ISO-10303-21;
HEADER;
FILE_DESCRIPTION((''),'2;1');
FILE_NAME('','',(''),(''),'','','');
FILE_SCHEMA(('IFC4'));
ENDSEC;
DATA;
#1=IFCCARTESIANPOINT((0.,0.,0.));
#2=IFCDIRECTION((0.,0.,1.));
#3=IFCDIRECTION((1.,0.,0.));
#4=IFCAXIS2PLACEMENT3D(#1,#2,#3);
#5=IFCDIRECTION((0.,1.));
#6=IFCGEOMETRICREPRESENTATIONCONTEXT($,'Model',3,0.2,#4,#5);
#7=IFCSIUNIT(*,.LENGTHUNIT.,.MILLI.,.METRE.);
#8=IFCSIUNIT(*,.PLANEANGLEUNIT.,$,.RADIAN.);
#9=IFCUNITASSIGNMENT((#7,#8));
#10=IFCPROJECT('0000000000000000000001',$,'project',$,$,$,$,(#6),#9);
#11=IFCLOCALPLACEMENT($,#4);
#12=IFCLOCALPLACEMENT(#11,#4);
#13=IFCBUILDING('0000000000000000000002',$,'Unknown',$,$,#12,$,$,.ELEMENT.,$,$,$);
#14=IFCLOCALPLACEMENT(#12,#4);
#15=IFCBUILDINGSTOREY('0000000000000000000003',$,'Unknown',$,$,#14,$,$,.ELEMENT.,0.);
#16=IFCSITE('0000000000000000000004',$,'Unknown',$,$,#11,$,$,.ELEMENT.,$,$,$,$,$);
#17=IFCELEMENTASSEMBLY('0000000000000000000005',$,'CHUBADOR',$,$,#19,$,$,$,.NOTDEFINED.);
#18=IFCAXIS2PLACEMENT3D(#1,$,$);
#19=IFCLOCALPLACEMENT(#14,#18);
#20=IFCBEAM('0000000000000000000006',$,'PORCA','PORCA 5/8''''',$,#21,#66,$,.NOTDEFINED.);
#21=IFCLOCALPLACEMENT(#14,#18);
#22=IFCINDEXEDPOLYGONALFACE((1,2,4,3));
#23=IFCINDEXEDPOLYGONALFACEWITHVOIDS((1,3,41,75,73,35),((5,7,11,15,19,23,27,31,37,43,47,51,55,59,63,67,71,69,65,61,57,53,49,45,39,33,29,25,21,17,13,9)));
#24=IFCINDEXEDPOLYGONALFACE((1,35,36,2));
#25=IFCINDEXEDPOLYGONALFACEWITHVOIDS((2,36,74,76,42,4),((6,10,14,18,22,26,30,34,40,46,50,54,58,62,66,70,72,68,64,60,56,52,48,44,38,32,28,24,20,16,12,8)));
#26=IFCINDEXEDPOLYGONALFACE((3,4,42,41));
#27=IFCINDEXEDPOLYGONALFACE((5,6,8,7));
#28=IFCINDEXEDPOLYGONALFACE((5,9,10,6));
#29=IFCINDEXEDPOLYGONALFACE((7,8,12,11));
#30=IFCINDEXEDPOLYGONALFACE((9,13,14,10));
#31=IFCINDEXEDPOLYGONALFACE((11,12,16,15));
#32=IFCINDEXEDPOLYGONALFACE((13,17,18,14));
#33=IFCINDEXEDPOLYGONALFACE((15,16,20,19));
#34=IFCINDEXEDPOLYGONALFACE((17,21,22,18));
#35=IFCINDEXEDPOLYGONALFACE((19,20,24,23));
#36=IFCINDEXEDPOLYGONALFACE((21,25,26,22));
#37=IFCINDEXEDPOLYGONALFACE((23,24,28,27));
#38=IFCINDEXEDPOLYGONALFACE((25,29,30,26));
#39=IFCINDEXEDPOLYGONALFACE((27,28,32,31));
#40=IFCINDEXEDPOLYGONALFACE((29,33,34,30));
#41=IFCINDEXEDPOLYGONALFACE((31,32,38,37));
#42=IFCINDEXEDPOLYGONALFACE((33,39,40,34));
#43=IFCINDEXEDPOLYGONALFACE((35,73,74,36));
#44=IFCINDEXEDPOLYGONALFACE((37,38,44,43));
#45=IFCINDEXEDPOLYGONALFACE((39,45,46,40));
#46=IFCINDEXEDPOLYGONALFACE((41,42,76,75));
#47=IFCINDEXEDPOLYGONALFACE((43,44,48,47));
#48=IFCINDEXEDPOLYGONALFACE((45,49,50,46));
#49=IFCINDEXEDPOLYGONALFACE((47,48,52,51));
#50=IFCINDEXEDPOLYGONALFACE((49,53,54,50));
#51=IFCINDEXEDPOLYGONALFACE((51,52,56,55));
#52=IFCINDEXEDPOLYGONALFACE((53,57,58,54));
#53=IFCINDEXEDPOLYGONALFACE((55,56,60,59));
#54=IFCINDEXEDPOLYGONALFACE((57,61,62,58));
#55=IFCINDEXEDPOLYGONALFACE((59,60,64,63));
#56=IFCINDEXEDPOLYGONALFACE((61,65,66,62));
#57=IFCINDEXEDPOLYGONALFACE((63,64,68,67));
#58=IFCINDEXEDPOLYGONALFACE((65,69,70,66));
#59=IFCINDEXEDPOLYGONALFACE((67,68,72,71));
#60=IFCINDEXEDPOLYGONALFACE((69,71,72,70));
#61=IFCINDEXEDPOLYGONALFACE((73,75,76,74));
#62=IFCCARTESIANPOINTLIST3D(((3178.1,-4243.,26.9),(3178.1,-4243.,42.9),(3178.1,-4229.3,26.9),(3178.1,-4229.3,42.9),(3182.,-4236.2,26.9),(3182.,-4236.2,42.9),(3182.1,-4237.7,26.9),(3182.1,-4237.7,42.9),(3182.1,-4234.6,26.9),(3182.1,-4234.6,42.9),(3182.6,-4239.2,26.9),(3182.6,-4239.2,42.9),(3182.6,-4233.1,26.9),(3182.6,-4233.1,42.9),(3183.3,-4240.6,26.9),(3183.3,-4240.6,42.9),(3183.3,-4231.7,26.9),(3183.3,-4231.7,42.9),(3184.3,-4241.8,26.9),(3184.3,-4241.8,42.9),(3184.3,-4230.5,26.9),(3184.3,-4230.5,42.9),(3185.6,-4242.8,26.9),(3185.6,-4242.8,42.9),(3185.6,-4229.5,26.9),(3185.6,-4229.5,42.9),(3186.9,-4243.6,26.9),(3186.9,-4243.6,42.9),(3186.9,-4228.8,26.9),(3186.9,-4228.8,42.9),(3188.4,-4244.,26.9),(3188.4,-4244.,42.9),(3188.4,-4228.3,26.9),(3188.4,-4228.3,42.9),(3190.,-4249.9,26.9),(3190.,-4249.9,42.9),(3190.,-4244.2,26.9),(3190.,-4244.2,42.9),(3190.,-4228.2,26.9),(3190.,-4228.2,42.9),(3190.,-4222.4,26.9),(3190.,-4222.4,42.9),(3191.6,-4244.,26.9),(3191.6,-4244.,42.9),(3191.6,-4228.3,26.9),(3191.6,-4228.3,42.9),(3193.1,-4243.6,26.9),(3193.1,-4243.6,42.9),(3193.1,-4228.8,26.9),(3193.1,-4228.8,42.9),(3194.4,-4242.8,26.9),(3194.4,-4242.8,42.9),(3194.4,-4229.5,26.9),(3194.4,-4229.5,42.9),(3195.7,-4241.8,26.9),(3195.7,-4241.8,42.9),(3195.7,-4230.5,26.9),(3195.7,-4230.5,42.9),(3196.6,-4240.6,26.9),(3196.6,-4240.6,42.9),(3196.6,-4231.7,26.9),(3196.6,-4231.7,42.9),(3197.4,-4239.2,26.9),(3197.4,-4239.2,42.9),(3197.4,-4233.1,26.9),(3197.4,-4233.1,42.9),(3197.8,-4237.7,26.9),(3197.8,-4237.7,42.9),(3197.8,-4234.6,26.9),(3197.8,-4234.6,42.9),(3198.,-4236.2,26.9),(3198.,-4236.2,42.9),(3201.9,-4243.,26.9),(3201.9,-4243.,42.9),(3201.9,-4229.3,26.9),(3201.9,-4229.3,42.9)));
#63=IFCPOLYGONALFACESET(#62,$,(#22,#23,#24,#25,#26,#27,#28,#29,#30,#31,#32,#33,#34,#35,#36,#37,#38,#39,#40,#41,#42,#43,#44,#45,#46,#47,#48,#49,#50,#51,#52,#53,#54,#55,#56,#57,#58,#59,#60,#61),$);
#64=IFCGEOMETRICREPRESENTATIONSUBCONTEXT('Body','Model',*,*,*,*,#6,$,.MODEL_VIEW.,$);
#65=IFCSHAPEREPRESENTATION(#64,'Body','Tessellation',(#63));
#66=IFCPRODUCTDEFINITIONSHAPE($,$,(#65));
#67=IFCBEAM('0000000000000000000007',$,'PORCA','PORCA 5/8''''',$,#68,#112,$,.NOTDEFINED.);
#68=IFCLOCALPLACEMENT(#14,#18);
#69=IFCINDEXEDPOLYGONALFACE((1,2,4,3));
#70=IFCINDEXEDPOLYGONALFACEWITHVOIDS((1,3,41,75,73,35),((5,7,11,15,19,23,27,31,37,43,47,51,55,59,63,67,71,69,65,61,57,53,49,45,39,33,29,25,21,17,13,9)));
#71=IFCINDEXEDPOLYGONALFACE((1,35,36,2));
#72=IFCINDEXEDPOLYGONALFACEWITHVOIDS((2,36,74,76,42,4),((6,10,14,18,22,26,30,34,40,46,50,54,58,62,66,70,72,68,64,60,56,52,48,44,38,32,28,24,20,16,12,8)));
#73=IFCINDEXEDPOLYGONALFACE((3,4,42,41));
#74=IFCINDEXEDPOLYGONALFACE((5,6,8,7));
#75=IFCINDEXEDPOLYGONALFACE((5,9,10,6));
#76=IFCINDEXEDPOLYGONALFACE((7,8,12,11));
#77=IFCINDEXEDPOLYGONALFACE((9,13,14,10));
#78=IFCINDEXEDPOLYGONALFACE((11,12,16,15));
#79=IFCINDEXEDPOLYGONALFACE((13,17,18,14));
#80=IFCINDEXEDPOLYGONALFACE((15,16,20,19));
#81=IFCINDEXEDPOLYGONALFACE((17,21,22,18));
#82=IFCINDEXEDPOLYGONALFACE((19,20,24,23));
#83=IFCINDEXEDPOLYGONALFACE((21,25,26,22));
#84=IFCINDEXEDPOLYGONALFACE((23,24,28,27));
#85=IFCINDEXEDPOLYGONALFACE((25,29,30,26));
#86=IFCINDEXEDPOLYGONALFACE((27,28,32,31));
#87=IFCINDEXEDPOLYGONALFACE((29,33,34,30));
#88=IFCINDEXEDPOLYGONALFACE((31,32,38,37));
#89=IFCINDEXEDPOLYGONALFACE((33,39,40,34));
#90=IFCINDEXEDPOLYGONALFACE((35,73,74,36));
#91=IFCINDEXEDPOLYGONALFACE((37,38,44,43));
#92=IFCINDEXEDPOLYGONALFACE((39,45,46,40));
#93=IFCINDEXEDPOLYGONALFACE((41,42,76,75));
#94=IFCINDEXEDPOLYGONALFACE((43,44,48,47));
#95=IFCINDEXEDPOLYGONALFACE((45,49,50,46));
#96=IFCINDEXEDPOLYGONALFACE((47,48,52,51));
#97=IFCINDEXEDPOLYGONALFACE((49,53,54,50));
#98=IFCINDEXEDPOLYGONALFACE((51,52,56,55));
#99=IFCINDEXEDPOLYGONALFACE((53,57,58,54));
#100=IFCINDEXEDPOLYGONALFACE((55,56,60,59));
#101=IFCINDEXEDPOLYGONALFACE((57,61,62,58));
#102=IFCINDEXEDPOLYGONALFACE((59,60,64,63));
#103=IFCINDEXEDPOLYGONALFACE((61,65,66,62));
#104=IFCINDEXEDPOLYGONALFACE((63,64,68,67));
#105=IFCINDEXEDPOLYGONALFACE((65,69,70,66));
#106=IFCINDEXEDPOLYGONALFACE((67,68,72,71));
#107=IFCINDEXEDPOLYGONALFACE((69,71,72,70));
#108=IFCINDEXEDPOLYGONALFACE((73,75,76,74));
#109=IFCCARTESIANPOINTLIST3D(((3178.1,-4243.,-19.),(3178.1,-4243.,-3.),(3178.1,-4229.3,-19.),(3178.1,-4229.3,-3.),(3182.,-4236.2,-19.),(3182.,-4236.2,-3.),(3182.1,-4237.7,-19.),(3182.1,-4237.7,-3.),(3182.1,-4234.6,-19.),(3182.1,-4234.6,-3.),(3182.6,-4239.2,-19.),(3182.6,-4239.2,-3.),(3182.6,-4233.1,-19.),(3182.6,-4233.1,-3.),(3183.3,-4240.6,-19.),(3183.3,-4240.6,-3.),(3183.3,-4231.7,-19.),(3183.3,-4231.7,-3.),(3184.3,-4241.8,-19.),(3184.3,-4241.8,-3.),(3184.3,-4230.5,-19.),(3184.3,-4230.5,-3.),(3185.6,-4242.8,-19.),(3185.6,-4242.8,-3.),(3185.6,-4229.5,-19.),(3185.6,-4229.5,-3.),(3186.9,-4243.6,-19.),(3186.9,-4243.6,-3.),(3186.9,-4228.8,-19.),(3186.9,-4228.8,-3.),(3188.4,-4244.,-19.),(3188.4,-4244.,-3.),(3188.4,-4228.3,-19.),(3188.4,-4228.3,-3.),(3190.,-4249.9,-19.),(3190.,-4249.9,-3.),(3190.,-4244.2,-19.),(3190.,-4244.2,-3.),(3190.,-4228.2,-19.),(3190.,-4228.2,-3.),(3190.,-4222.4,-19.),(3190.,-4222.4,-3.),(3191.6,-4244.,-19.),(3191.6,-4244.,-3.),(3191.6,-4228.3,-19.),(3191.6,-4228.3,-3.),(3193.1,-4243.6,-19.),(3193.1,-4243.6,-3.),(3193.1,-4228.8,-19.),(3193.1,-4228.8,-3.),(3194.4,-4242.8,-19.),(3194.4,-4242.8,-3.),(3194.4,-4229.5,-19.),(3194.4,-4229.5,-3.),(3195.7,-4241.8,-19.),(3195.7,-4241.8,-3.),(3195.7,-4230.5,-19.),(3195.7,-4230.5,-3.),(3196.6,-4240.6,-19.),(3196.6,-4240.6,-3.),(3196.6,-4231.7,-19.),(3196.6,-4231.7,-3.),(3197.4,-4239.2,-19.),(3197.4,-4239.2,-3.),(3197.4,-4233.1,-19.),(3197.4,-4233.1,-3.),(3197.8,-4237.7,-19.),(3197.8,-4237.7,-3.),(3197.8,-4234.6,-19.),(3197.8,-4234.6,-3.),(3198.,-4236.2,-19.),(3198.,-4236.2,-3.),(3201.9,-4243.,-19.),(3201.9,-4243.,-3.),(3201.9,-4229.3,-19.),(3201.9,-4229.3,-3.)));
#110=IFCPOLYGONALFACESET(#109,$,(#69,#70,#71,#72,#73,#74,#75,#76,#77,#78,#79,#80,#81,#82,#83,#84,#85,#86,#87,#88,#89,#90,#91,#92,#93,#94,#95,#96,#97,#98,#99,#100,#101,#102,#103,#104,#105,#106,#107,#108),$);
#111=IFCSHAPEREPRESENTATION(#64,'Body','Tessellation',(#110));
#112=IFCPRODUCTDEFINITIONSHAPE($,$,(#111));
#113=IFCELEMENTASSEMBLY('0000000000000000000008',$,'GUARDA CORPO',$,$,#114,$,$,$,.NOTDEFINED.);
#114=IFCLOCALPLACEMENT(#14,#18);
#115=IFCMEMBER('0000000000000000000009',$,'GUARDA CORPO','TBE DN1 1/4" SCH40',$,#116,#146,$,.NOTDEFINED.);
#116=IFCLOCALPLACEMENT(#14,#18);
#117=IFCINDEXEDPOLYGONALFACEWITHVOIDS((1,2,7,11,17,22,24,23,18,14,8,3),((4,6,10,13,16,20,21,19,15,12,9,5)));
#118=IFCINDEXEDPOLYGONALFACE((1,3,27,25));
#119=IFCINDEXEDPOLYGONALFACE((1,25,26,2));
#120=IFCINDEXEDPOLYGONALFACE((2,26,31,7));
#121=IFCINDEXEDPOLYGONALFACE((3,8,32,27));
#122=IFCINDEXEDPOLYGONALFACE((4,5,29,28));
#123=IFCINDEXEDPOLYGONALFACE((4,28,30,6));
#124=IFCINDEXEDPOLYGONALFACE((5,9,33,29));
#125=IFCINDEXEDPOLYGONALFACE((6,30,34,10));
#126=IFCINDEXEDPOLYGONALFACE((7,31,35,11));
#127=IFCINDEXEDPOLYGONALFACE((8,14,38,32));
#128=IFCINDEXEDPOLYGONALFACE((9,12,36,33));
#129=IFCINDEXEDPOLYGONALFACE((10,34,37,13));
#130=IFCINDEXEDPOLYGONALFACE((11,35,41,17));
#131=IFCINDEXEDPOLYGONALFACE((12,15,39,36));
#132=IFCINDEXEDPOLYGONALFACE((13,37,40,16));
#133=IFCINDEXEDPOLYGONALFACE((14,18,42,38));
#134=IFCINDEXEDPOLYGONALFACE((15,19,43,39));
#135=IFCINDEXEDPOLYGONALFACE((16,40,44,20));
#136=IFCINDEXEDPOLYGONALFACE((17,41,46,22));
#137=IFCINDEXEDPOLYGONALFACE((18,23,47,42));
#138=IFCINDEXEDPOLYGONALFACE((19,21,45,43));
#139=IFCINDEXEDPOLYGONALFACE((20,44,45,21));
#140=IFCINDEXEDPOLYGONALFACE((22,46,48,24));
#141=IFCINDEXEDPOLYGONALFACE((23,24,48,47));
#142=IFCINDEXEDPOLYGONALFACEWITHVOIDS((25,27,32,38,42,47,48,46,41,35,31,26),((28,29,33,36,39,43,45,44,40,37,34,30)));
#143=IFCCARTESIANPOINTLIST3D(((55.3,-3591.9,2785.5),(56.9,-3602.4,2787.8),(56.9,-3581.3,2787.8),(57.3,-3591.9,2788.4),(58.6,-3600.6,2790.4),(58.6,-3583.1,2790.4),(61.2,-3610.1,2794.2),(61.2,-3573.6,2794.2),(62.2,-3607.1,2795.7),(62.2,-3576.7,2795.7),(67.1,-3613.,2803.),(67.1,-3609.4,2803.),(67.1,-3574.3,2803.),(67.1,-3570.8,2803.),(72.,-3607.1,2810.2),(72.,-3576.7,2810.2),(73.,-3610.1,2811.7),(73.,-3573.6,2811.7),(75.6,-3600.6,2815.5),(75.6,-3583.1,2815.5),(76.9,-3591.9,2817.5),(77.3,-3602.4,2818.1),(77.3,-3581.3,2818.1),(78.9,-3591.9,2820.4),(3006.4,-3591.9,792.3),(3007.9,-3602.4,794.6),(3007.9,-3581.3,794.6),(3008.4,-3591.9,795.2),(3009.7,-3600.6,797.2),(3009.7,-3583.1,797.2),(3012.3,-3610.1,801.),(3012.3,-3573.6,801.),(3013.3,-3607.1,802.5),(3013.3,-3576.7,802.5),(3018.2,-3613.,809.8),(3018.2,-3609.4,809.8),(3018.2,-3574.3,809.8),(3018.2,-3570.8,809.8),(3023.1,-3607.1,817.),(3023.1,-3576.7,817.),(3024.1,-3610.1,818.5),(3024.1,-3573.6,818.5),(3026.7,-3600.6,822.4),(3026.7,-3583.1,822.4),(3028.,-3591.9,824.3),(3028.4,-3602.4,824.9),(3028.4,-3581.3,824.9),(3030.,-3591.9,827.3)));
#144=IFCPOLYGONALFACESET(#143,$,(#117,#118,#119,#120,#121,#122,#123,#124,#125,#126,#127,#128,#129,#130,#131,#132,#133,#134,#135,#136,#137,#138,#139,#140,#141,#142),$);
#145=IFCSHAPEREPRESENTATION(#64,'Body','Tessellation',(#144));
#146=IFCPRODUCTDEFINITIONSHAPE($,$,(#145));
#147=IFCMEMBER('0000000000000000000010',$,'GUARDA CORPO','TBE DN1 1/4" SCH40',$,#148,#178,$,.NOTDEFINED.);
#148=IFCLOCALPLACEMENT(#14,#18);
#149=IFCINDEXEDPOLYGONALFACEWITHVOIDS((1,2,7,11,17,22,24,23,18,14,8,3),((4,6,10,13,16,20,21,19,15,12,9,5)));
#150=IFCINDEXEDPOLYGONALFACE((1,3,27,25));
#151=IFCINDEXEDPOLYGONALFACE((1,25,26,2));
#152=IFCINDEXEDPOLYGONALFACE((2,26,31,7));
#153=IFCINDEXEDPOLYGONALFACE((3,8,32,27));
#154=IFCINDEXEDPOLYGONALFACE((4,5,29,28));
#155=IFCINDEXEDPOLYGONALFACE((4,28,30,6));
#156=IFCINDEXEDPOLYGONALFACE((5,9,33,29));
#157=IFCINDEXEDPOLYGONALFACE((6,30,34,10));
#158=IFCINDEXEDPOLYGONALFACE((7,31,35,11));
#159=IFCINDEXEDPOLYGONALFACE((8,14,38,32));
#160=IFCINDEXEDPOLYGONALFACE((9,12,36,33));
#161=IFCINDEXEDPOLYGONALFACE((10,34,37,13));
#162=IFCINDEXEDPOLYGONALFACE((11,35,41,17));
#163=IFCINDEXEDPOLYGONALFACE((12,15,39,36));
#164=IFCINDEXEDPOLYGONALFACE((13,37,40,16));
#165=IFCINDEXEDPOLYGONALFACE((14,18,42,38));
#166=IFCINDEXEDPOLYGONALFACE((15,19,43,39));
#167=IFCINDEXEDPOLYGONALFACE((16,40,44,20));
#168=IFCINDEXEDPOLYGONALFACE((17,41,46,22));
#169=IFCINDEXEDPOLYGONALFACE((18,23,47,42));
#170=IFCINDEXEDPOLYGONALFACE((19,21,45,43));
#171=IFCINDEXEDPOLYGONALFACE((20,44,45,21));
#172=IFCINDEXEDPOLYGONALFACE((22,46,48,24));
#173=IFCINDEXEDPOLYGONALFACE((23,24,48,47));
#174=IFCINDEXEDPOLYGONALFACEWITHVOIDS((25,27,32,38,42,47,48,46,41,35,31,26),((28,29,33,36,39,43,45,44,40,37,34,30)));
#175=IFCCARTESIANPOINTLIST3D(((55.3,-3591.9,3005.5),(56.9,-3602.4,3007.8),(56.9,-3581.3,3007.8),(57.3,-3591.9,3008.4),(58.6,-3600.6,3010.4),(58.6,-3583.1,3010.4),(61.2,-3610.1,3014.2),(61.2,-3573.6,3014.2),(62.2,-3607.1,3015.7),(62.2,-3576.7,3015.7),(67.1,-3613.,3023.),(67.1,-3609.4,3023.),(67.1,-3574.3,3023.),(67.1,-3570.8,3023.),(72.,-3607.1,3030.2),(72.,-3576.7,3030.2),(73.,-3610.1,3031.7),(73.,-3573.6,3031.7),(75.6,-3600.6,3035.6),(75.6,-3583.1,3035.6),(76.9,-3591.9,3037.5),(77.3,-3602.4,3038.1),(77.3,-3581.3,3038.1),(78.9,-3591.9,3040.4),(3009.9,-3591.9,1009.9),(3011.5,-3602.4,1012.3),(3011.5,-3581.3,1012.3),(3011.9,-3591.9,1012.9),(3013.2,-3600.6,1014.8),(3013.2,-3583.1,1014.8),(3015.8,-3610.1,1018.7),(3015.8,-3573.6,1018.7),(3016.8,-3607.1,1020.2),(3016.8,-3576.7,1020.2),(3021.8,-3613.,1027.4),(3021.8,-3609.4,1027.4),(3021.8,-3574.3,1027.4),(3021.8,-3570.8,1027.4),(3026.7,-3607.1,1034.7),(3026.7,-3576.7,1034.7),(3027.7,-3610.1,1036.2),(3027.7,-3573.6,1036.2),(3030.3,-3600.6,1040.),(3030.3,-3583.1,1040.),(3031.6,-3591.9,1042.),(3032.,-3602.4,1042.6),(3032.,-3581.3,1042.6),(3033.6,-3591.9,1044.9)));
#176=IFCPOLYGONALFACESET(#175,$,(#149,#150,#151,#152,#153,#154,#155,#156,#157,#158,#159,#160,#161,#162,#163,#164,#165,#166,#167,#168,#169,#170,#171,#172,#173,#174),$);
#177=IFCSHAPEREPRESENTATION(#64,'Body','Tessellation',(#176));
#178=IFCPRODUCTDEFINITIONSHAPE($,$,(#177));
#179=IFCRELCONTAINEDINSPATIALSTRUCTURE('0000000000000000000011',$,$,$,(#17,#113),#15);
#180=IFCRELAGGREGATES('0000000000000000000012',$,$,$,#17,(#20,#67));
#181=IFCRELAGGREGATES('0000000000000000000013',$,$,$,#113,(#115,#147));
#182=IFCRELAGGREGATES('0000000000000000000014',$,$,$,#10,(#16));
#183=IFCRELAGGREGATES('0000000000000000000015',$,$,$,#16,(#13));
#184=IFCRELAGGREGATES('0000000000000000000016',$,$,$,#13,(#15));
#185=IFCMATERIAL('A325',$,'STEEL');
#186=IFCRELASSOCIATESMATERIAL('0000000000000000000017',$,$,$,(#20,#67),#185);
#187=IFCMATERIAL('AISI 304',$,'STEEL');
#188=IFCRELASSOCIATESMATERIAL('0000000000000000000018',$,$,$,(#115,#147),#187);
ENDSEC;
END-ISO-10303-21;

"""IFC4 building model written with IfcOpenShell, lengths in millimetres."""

from ifc_helpers import new_model, si_unit, direction, frame, origin_with_axes, place, context, subcontext, project, spatial, line, indexed_curve, outline, extrude, material, element, aggregate, save


model = new_model("IFC4")

# Units and contexts
model_context = context("Model", 3, precision=0.2, world=origin_with_axes(), true_north=direction((0.0, 1.0)))
body_context = subcontext(model_context, "Body", "Model", "MODEL_VIEW")
ifc_project = project(units=[si_unit("LENGTHUNIT", "METRE", prefix="MILLI"), si_unit("PLANEANGLEUNIT", "RADIAN")], contexts=[model_context])

# Site, building, storey
site_placement = place(None, origin_with_axes())
site = spatial("IfcSite", under=ifc_project, at=site_placement, Name="Unknown", CompositionType="ELEMENT")
building_placement = place(site_placement, origin_with_axes())
building = spatial("IfcBuilding", under=site, at=building_placement, Name="Unknown", CompositionType="ELEMENT")
storey_placement = place(building_placement, origin_with_axes())
storey = spatial("IfcBuildingStorey", under=building, at=storey_placement, Name="Unknown", CompositionType="ELEMENT", Elevation=0.0)

# Element assembly, beams
ifc_material_1 = material(Name="A325", Category="STEEL")
assembly_1_placement = place(storey_placement, frame((3190.0, -4236.2, -52.1), z_axis=(1.0, 0.0, 0.0), x_axis=(0.0, 0.0, -1.0)))
assembly_1 = element("IfcElementAssembly", 1, at=assembly_1_placement, inside=storey, Name="CHUBADOR", PredefinedType="NOTDEFINED")
beam_1_placement = place(assembly_1_placement, frame((-95.0, 0.0, 0.0), z_axis=(0.0, 0.0, 1.0), x_axis=(1.0, 0.0, 0.0)))
beam_1 = element("IfcBeam", 2, at=beam_1_placement, material=ifc_material_1, Name="PORCA", Description="PORCA 5/8''", PredefinedType="NOTDEFINED", context=body_context, shape_type="SolidModel", body=[
    extrude(outline(indexed_curve([(0.0, 13.8), (-11.9, 6.9), (-11.9, -6.9), (0.0, -13.8), (11.9, -6.9), (11.9, 6.9)], segments=[line(1, 2, 3, 4, 5, 6, 1)]), holes=[indexed_curve([(7.8, 1.6), (8.0, 0.0), (7.8, -1.6), (7.4, -3.1), (6.7, -4.4), (5.7, -5.7), (4.4, -6.7), (3.1, -7.4), (1.6, -7.8), (0.0, -8.0), (-1.6, -7.8), (-3.1, -7.4), (-4.4, -6.7), (-5.7, -5.7), (-6.7, -4.4), (-7.4, -3.1), (-7.8, -1.6), (-8.0, 0.0), (-7.8, 1.6), (-7.4, 3.1), (-6.7, 4.4), (-5.7, 5.7), (-4.4, 6.7), (-3.1, 7.4), (-1.6, 7.8), (0.0, 8.0), (1.6, 7.8), (3.1, 7.4), (4.4, 6.7), (5.7, 5.7), (6.7, 4.4), (7.4, 3.1)], segments=[line(1, 2, 3, 4, 5, 6, 7, 8, 9, 10, 11, 12, 13, 14, 15, 16, 17, 18, 19, 20, 21, 22, 23, 24, 25, 26, 27, 28, 29, 30, 31, 32, 1)])]), frame((0.0, 0.0, 0.0), z_axis=(-1.0, 0.0, 0.0), x_axis=(0.0, 0.0, 1.0)), (0.0, 0.0, -1.0), 16.0),
])
beam_2_placement = place(assembly_1_placement, frame((-49.1, 0.0, 0.0), z_axis=(0.0, 0.0, 1.0), x_axis=(1.0, 0.0, 0.0)))
beam_2 = element("IfcBeam", 3, at=beam_2_placement, material=ifc_material_1, Name="PORCA", Description="PORCA 5/8''", PredefinedType="NOTDEFINED", context=body_context, shape_type="SolidModel", body=[
    extrude(outline(indexed_curve([(0.0, 13.8), (-11.9, 6.9), (-11.9, -6.9), (0.0, -13.8), (11.9, -6.9), (11.9, 6.9)], segments=[line(1, 2, 3, 4, 5, 6, 1)]), holes=[indexed_curve([(7.8, 1.6), (8.0, 0.0), (7.8, -1.6), (7.4, -3.1), (6.7, -4.4), (5.7, -5.7), (4.4, -6.7), (3.1, -7.4), (1.6, -7.8), (0.0, -8.0), (-1.6, -7.8), (-3.1, -7.4), (-4.4, -6.7), (-5.7, -5.7), (-6.7, -4.4), (-7.4, -3.1), (-7.8, -1.6), (-8.0, 0.0), (-7.8, 1.6), (-7.4, 3.1), (-6.7, 4.4), (-5.7, 5.7), (-4.4, 6.7), (-3.1, 7.4), (-1.6, 7.8), (0.0, 8.0), (1.6, 7.8), (3.1, 7.4), (4.4, 6.7), (5.7, 5.7), (6.7, 4.4), (7.4, 3.1)], segments=[line(1, 2, 3, 4, 5, 6, 7, 8, 9, 10, 11, 12, 13, 14, 15, 16, 17, 18, 19, 20, 21, 22, 23, 24, 25, 26, 27, 28, 29, 30, 31, 32, 1)])]), frame((0.0, 0.0, 0.0), z_axis=(-1.0, 0.0, 0.0), x_axis=(0.0, 0.0, 1.0)), (0.0, 0.0, -1.0), 16.0),
])
aggregate(assembly_1, [beam_1, beam_2])

# Element assembly, members
assembly_2_placement = place(storey_placement, frame((833.2, -3540.7, 1615.0), z_axis=(-0.000512, -1.0, -0.000003), x_axis=(0.000003, -0.000003, 1.0)))
assembly_2 = element("IfcElementAssembly", 4, at=assembly_2_placement, inside=storey, Name="GUARDA CORPO", PredefinedType="NOTDEFINED")
ifc_material_2 = material(Name="AISI 304", Category="STEEL")
member_1_placement = place(assembly_2_placement, frame((-805.2, -2185.0, 50.0), z_axis=(-0.828691, 0.559706, 0.000289), x_axis=(0.559706, 0.828691, 0.000423)))
member_1 = element("IfcMember", 5, at=member_1_placement, material=ifc_material_2, Name="GUARDA CORPO", Description="TBE DN1 1/4\" SCH40", PredefinedType="NOTDEFINED", context=body_context, shape_type="SolidModel", body=[
    extrude(outline(indexed_curve([(21.1, 0.0), (18.3, 10.6), (10.6, 18.3), (0.0, 21.1), (-10.6, 18.3), (-18.3, 10.6), (-21.1, 0.0), (-18.3, -10.6), (-10.6, -18.3), (0.0, -21.1), (10.6, -18.3), (18.3, -10.6)], segments=[line(1, 2, 3, 4, 5, 6, 7, 8, 9, 10, 11, 12, 1)]), holes=[indexed_curve([(17.5, 0.0), (15.2, -8.8), (8.8, -15.2), (0.0, -17.5), (-8.8, -15.2), (-15.2, -8.8), (-17.5, 0.0), (-15.2, 8.8), (-8.8, 15.2), (0.0, 17.5), (8.8, 15.2), (15.2, 8.8)], segments=[line(1, 2, 3, 4, 5, 6, 7, 8, 9, 10, 11, 12, 1)])]), frame((0.0, 0.0, 0.0), z_axis=(-1.0, 0.0, 0.0), x_axis=(0.0, 0.0, 1.0)), (0.0, 0.0, -1.0), 3561.1),
])
member_2_placement = place(assembly_2_placement, frame((-587.6, -2188.6, 50.0), z_axis=(-0.828699, 0.559694, 0.000289), x_axis=(0.559694, 0.828699, 0.000423)))
member_2 = element("IfcMember", 6, at=member_2_placement, material=ifc_material_2, Name="GUARDA CORPO", Description="TBE DN1 1/4\" SCH40", PredefinedType="NOTDEFINED", context=body_context, shape_type="SolidModel", body=[
    extrude(outline(indexed_curve([(21.1, 0.0), (18.3, 10.6), (10.6, 18.3), (0.0, 21.1), (-10.6, 18.3), (-18.3, 10.6), (-21.1, 0.0), (-18.3, -10.6), (-10.6, -18.3), (0.0, -21.1), (10.6, -18.3), (18.3, -10.6)], segments=[line(1, 2, 3, 4, 5, 6, 7, 8, 9, 10, 11, 12, 1)]), holes=[indexed_curve([(17.5, 0.0), (15.2, -8.8), (8.8, -15.2), (0.0, -17.5), (-8.8, -15.2), (-15.2, -8.8), (-17.5, 0.0), (-15.2, 8.8), (-8.8, 15.2), (0.0, 17.5), (8.8, 15.2), (15.2, 8.8)], segments=[line(1, 2, 3, 4, 5, 6, 7, 8, 9, 10, 11, 12, 1)])]), frame((0.0, 0.0, 0.0), z_axis=(-1.0, 0.0, 0.0), x_axis=(0.0, 0.0, 1.0)), (0.0, 0.0, -1.0), 3565.4),
])
aggregate(assembly_2, [member_1, member_2])

save(model, "model.ifc")
